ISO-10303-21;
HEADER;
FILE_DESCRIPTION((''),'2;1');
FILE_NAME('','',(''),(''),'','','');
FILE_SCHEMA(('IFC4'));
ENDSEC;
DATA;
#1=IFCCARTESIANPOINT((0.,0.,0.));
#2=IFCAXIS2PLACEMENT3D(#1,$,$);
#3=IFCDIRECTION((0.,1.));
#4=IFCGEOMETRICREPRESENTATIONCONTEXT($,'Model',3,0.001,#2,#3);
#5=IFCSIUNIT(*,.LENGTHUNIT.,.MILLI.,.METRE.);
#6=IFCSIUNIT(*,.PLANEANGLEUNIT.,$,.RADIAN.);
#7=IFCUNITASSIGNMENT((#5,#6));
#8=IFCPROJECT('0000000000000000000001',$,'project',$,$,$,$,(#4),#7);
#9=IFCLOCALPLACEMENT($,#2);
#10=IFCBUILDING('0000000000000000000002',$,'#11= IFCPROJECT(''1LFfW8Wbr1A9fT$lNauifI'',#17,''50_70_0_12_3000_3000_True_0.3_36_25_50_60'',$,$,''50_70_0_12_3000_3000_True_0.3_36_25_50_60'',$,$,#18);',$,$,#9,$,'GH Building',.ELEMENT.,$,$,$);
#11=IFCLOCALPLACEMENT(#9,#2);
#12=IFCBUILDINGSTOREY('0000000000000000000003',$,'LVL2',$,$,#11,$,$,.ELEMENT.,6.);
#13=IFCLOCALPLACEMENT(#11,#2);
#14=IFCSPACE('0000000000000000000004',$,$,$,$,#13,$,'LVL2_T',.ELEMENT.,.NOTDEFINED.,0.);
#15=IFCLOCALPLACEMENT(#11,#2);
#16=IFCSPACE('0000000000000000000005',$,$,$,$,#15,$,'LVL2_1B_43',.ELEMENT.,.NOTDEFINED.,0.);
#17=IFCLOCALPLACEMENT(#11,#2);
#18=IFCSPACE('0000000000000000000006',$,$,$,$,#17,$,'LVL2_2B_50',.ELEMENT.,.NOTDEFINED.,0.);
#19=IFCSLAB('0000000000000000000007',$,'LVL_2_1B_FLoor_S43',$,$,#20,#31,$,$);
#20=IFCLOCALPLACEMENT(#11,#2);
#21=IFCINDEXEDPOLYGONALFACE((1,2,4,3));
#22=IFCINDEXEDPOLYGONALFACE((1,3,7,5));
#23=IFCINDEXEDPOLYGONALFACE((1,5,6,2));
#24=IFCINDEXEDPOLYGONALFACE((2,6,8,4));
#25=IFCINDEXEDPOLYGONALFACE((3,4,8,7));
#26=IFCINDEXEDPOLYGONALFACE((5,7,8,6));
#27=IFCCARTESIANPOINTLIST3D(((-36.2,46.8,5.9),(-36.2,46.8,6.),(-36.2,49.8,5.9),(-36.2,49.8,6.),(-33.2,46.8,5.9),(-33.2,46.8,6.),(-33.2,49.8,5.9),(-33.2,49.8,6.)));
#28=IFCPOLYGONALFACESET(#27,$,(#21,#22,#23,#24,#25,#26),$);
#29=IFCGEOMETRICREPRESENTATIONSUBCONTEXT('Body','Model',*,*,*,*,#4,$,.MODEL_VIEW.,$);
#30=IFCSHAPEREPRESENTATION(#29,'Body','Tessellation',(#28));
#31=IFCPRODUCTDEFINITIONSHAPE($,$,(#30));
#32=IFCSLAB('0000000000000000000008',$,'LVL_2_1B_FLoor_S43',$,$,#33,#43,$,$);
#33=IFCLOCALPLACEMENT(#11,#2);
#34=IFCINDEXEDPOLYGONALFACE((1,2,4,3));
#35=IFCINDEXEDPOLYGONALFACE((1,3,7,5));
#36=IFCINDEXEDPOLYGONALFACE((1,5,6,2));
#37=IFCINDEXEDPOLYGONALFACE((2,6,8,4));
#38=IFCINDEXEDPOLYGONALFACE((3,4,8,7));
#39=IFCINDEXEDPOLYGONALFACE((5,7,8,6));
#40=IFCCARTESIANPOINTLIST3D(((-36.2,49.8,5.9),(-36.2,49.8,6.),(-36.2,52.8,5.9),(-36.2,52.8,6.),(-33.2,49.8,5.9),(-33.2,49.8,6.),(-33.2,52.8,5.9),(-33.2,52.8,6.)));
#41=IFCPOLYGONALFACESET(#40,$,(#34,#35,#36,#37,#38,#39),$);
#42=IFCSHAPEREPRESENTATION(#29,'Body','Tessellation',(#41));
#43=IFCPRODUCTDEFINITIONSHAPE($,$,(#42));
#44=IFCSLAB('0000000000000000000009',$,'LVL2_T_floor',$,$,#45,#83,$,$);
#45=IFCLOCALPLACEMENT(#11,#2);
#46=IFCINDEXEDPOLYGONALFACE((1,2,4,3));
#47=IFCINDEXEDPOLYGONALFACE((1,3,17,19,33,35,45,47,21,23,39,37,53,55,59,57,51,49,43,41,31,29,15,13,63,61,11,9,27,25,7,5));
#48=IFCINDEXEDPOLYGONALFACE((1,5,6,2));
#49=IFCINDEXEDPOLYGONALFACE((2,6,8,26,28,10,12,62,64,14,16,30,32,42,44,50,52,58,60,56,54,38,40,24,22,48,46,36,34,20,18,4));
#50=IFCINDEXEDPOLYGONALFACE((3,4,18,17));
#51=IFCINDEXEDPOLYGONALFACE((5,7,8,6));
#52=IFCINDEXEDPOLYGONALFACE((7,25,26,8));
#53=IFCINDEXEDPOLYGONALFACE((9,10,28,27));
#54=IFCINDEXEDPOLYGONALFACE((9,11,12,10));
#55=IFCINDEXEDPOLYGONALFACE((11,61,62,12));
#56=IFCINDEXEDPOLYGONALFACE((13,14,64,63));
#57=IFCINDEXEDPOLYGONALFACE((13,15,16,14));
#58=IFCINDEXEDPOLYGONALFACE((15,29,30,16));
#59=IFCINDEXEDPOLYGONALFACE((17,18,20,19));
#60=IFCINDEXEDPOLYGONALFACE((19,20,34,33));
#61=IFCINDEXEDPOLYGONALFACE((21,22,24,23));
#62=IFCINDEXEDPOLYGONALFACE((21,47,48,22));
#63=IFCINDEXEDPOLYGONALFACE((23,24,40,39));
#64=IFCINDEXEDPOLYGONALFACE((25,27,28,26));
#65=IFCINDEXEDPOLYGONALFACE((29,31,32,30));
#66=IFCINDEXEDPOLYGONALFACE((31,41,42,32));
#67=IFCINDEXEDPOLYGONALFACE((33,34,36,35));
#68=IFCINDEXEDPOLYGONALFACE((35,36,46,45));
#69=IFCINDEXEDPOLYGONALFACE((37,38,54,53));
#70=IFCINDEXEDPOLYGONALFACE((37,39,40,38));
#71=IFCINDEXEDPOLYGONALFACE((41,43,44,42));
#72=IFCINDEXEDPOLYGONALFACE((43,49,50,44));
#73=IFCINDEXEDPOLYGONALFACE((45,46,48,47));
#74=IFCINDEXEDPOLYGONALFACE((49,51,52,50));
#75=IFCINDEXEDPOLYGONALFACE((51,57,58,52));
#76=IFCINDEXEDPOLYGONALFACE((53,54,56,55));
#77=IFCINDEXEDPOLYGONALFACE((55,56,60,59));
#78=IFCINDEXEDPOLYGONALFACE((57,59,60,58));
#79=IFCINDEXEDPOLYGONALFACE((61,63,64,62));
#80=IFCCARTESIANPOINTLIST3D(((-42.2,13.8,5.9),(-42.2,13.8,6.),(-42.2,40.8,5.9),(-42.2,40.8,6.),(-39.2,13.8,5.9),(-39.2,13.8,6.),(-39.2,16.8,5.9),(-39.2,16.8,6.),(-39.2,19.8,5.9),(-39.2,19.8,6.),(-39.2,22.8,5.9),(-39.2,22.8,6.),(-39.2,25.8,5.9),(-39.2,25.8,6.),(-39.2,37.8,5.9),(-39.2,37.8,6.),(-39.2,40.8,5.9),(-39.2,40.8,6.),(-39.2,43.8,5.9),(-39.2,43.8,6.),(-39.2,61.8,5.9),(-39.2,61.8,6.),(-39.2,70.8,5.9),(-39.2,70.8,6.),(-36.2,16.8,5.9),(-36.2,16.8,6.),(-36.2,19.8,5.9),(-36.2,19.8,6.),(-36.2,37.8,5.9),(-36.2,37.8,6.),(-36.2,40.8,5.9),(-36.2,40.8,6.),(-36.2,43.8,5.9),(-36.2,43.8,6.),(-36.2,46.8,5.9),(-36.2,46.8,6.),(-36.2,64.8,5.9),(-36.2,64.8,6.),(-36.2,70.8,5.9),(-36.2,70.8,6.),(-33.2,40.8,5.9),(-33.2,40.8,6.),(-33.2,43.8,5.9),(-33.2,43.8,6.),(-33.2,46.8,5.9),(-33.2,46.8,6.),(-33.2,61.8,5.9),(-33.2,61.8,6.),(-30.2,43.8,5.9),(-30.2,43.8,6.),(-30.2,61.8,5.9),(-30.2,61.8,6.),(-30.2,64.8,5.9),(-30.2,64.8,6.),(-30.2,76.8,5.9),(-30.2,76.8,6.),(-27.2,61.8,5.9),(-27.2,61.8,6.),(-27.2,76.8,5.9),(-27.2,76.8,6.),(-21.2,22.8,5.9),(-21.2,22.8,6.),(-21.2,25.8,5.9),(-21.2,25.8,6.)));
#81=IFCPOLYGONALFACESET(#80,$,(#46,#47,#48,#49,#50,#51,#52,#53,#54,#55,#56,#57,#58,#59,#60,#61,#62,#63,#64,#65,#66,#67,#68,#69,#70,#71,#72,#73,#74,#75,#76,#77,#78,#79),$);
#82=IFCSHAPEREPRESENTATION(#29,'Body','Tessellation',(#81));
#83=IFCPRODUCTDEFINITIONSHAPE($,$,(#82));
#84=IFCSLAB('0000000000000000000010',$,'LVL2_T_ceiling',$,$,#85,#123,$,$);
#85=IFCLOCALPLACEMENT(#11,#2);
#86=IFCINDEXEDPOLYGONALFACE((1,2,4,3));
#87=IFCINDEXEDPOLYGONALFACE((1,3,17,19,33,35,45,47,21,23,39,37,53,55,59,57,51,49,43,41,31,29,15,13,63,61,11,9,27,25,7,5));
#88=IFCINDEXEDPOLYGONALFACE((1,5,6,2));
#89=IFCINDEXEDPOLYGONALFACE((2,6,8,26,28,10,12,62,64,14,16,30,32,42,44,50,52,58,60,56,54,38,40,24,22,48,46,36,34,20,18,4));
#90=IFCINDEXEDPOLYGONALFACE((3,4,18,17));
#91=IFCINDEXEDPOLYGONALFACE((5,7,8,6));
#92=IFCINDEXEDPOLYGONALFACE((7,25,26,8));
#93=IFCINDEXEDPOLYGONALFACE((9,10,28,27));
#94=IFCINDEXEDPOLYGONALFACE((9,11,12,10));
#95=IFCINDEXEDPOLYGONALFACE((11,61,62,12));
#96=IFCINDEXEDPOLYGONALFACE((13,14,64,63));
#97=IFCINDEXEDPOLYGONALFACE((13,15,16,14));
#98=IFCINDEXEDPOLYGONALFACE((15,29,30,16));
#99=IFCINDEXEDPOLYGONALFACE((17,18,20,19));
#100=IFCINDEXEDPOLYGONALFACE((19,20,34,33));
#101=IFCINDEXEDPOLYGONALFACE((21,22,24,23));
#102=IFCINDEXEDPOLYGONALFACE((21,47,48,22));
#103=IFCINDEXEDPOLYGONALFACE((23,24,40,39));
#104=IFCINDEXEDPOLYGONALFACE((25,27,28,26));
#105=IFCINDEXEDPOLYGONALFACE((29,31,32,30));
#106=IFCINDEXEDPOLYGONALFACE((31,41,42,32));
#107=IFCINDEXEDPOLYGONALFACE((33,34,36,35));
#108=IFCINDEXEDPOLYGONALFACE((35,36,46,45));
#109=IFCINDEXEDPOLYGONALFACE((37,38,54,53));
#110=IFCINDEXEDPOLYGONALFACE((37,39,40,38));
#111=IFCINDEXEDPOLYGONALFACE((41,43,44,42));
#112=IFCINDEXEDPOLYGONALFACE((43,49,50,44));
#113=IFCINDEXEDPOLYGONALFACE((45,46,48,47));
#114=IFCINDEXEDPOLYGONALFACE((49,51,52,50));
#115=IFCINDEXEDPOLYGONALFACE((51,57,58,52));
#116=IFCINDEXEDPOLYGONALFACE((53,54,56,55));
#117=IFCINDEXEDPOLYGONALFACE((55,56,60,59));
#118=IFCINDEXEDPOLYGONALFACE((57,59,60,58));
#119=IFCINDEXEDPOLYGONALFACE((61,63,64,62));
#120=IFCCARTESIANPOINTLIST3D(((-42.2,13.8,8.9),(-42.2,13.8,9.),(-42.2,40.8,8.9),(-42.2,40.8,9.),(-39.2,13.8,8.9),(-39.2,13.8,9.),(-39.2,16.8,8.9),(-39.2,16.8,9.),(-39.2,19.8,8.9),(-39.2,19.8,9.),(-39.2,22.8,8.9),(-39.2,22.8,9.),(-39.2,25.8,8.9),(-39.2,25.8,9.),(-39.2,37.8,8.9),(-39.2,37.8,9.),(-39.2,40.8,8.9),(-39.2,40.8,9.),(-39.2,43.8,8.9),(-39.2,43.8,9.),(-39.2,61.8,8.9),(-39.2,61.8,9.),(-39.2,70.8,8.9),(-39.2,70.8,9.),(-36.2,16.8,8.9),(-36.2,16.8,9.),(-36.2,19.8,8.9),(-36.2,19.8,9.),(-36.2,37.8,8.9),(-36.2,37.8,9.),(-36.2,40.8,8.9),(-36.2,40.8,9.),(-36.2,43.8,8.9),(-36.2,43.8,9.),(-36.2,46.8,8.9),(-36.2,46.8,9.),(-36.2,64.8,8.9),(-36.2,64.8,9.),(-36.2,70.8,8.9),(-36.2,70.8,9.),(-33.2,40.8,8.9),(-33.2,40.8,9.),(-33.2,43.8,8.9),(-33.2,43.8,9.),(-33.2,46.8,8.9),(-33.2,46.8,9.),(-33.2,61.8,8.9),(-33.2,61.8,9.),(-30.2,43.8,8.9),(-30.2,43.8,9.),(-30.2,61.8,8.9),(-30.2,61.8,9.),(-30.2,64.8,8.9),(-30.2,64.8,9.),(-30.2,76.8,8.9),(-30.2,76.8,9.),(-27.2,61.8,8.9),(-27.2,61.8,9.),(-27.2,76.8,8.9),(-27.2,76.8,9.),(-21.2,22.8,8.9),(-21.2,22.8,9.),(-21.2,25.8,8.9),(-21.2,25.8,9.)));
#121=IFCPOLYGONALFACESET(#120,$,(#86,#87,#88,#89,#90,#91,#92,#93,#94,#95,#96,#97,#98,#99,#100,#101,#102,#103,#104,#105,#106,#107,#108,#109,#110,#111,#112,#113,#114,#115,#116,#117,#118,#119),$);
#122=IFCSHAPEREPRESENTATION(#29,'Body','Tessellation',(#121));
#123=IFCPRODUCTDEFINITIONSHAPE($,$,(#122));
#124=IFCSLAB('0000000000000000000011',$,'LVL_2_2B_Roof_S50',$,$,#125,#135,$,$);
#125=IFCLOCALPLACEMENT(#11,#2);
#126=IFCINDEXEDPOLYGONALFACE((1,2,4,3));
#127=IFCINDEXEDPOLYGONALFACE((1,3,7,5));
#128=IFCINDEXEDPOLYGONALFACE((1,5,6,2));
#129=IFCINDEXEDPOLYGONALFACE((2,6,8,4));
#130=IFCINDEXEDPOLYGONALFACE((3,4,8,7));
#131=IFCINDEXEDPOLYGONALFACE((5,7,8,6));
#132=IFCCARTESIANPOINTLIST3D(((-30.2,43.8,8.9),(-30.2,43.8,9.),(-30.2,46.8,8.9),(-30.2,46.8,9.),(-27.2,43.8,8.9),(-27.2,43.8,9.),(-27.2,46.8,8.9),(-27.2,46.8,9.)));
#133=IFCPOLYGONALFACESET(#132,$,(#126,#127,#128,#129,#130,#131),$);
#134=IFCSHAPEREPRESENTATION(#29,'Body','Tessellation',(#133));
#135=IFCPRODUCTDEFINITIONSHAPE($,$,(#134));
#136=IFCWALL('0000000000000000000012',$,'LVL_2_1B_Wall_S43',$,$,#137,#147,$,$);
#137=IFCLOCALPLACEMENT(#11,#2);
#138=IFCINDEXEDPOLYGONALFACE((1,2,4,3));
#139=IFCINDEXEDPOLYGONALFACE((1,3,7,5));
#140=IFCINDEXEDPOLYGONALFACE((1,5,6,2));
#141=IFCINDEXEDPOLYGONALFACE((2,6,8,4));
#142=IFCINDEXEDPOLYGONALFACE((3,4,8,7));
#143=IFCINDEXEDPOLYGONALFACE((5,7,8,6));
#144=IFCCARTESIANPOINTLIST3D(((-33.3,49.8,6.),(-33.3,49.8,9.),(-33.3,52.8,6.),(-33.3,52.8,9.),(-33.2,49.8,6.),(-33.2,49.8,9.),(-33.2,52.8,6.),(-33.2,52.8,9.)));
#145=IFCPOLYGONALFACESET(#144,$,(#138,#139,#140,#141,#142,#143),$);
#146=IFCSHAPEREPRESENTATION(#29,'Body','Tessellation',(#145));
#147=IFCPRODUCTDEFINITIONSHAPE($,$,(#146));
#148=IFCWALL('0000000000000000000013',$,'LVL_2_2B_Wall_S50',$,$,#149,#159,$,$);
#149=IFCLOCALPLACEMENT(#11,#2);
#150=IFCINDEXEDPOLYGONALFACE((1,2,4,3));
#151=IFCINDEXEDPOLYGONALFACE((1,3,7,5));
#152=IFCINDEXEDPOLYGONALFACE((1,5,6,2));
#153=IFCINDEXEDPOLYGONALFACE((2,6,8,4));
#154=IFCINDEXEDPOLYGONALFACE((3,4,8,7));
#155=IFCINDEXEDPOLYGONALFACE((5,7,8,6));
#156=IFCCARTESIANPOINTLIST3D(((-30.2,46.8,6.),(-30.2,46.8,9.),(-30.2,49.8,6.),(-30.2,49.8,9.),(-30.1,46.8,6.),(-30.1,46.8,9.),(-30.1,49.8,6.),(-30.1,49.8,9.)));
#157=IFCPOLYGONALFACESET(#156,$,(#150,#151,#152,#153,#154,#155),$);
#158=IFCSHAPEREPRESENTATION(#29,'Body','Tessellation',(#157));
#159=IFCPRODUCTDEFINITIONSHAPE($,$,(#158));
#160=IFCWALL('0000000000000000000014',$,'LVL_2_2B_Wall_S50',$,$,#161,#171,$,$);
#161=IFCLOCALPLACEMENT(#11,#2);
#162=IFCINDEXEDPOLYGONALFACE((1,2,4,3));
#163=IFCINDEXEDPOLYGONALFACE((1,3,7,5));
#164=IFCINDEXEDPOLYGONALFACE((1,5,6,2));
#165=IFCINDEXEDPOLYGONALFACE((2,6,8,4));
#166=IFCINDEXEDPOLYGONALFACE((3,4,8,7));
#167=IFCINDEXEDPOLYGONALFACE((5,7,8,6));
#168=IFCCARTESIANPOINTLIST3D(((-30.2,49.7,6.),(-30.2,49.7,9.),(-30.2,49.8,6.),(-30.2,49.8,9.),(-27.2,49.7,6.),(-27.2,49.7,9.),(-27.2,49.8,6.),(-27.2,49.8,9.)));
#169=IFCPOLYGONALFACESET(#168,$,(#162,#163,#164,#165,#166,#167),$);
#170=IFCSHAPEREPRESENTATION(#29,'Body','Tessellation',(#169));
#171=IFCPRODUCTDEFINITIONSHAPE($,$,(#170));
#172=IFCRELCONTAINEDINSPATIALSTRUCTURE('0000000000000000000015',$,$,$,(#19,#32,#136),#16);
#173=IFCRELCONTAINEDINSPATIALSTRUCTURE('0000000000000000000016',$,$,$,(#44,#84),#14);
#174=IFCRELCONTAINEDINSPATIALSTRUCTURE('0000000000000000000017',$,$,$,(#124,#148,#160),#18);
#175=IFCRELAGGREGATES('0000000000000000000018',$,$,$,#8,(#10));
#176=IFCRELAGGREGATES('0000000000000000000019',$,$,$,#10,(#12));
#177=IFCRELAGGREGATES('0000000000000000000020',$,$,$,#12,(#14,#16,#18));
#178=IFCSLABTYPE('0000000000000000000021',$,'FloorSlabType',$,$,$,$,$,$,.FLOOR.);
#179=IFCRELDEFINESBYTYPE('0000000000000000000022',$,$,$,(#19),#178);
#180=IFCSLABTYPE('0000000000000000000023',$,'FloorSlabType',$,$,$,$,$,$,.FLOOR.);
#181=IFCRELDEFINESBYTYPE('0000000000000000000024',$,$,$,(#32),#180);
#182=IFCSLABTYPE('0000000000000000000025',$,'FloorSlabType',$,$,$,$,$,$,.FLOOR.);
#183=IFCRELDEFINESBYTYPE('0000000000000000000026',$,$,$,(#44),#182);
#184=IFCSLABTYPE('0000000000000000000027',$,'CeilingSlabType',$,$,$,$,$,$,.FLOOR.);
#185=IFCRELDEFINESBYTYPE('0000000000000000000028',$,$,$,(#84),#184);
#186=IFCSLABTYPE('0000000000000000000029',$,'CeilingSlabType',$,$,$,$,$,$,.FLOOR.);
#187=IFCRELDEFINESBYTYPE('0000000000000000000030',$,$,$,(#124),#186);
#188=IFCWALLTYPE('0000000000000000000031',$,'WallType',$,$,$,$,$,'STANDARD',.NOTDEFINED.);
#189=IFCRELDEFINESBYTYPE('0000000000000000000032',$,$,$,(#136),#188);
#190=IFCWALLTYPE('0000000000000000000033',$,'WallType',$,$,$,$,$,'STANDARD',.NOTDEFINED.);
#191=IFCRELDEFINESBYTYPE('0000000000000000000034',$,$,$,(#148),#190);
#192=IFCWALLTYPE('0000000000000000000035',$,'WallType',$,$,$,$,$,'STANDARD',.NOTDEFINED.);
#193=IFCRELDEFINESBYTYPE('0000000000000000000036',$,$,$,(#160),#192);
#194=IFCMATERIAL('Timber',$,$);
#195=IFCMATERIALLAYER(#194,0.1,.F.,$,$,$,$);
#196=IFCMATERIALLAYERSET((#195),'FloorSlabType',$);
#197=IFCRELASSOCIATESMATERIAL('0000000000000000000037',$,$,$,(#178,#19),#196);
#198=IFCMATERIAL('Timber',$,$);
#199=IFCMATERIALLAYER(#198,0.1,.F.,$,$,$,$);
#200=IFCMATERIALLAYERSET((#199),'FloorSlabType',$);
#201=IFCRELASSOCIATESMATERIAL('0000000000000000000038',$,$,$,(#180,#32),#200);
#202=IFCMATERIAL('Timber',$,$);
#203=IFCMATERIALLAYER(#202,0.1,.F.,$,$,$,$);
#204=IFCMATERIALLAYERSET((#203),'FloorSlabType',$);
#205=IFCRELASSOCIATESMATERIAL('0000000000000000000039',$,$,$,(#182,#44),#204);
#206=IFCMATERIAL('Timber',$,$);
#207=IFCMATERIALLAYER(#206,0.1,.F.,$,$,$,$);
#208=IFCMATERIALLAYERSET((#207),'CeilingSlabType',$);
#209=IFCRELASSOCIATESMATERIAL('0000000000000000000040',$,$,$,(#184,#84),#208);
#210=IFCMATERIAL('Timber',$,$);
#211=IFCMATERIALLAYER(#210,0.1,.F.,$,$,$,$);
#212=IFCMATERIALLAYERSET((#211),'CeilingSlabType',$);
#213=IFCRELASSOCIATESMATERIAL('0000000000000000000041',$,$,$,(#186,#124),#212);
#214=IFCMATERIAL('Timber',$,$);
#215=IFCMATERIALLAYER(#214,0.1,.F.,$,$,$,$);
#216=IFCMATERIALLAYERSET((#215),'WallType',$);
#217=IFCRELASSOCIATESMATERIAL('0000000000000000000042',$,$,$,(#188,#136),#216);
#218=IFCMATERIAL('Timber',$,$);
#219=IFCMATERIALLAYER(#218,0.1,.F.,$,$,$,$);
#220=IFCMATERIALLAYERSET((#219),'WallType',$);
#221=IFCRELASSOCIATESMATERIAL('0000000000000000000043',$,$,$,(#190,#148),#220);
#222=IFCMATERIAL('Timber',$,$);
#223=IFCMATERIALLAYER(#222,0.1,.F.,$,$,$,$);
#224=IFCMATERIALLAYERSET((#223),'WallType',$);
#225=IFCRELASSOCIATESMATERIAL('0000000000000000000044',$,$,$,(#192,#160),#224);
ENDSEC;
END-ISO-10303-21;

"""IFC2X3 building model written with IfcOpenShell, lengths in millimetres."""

from ifc_helpers import new_model, si_unit, direction, frame, frame_2d, origin, place, context, subcontext, project, spatial, polyline, rectangle, outline, extrude, material, layer, layer_set, layer_usage, type_object, element, save


model = new_model("IFC2X3")

# Units and contexts
model_context = context("Model", 3, precision=0.001, world=origin(), true_north=direction((0.0, 1.0)))
body_context = subcontext(model_context, "Body", "Model", "MODEL_VIEW")
ifc_project = project(units=[si_unit("LENGTHUNIT", "METRE", prefix="MILLI"), si_unit("PLANEANGLEUNIT", "RADIAN")], contexts=[model_context])

# Building, storey, space
building_placement = place(None, origin())
building = spatial("IfcBuilding", under=ifc_project, at=building_placement, Name="#11= IFCPROJECT('1LFfW8Wbr1A9fT$lNauifI',#17,'50_70_0_12_3000_3000_True_0.3_36_25_50_60',$,$,'50_70_0_12_3000_3000_True_0.3_36_25_50_60',$,$,#18);", LongName="GH Building", CompositionType="ELEMENT")
storey_placement = place(building_placement, origin())
storey = spatial("IfcBuildingStorey", under=building, at=storey_placement, Name="LVL2", CompositionType="ELEMENT", Elevation=6.0)
space_1_placement = place(storey_placement, origin())
space_1 = spatial("IfcSpace", under=storey, at=space_1_placement, LongName="LVL2_T", CompositionType="ELEMENT", InteriorOrExteriorSpace="NOTDEFINED", ElevationWithFlooring=0.0)

# Shared definitions
space_2_placement = place(storey_placement, origin())
space_2 = spatial("IfcSpace", under=storey, at=space_2_placement, LongName="LVL2_1B_43", CompositionType="ELEMENT", InteriorOrExteriorSpace="NOTDEFINED", ElevationWithFlooring=0.0)

# Slabs
ifc_material_1 = material(Name="Timber")
ifc_layer_1 = layer(ifc_material_1, 0.1, ventilated=False)
ifc_layer_set_1 = layer_set([ifc_layer_1], Name="FloorSlabType")
ifc_layer_usage_1 = layer_usage(ifc_layer_set_1, "AXIS3", "NEGATIVE", -0.1)
slab_type_1 = type_object("IfcSlabType", Name="FloorSlabType", PredefinedType="FLOOR", material=ifc_layer_set_1)
slab_1_placement = place(space_2_placement, frame((-33.2, 46.8, 5.9), z_axis=(0.0, 0.0, 1.0), x_axis=(0.0, 1.0, 0.0)))
element("IfcSlab", 1, at=slab_1_placement, inside=space_2, type_object=slab_type_1, material=ifc_layer_usage_1, Name="LVL_2_1B_FLoor_S43", context=body_context, shape_type="SweptSolid", body=[
    extrude(rectangle(XDim=3.0, YDim=3.0, at=frame_2d((1.5, 1.5))), origin(), (0.0, 0.0, 1.0), 0.1),
])
ifc_material_2 = material(Name="Timber")
ifc_layer_2 = layer(ifc_material_2, 0.1, ventilated=False)
ifc_layer_set_2 = layer_set([ifc_layer_2], Name="FloorSlabType")
ifc_layer_usage_2 = layer_usage(ifc_layer_set_2, "AXIS3", "NEGATIVE", -0.1)
slab_type_2 = type_object("IfcSlabType", Name="FloorSlabType", PredefinedType="FLOOR", material=ifc_layer_set_2)
slab_2_placement = place(space_2_placement, frame((-33.2, 49.8, 5.9), z_axis=(0.0, 0.0, 1.0), x_axis=(0.0, 1.0, 0.0)))
element("IfcSlab", 2, at=slab_2_placement, inside=space_2, type_object=slab_type_2, material=ifc_layer_usage_2, Name="LVL_2_1B_FLoor_S43", context=body_context, shape_type="SweptSolid", body=[
    extrude(rectangle(XDim=3.0, YDim=3.0, at=frame_2d((1.5, 1.5))), origin(), (0.0, 0.0, 1.0), 0.1),
])
ifc_material_3 = material(Name="Timber")
ifc_layer_3 = layer(ifc_material_3, 0.1, ventilated=False)
ifc_layer_set_3 = layer_set([ifc_layer_3], Name="FloorSlabType")
ifc_layer_usage_3 = layer_usage(ifc_layer_set_3, "AXIS3", "NEGATIVE", -0.1)
slab_type_3 = type_object("IfcSlabType", Name="FloorSlabType", PredefinedType="FLOOR", material=ifc_layer_set_3)
slab_3_placement = place(space_1_placement, frame((-31.7, 45.3, 5.9)))
element("IfcSlab", 3, at=slab_3_placement, inside=space_1, type_object=slab_type_3, material=ifc_layer_usage_3, Name="LVL2_T_floor", context=body_context, shape_type="SweptSolid", body=[
    extrude(outline(polyline([(-7.5, -7.5), (-4.5, -7.5), (-4.5, -4.5), (-1.5, -4.5), (-1.5, -1.5), (1.5, -1.5), (1.5, 16.5), (4.5, 16.5), (4.5, 31.5), (1.5, 31.5), (1.5, 19.5), (-4.5, 19.5), (-4.5, 25.5), (-7.5, 25.5), (-7.5, 16.5), (-1.5, 16.5), (-1.5, 1.5), (-4.5, 1.5), (-4.5, -1.5), (-7.5, -1.5), (-7.5, -4.5), (-10.5, -4.5), (-10.5, -31.5), (-7.5, -31.5), (-7.5, -28.5), (-4.5, -28.5), (-4.5, -25.5), (-7.5, -25.5), (-7.5, -22.5), (10.5, -22.5), (10.5, -19.5), (-7.5, -19.5), (-7.5, -7.5)])), origin(), (0.0, 0.0, 1.0), 0.1),
])
ifc_material_4 = material(Name="Timber")
ifc_layer_4 = layer(ifc_material_4, 0.1, ventilated=False)
ifc_layer_set_4 = layer_set([ifc_layer_4], Name="CeilingSlabType")
ifc_layer_usage_4 = layer_usage(ifc_layer_set_4, "AXIS3", "NEGATIVE", -0.1)
slab_type_4 = type_object("IfcSlabType", Name="CeilingSlabType", PredefinedType="FLOOR", material=ifc_layer_set_4)
slab_4_placement = place(space_1_placement, frame((-31.7, 45.3, 8.9)))
element("IfcSlab", 4, at=slab_4_placement, inside=space_1, type_object=slab_type_4, material=ifc_layer_usage_4, Name="LVL2_T_ceiling", context=body_context, shape_type="SweptSolid", body=[
    extrude(outline(polyline([(-7.5, -7.5), (-4.5, -7.5), (-4.5, -4.5), (-1.5, -4.5), (-1.5, -1.5), (1.5, -1.5), (1.5, 16.5), (4.5, 16.5), (4.5, 31.5), (1.5, 31.5), (1.5, 19.5), (-4.5, 19.5), (-4.5, 25.5), (-7.5, 25.5), (-7.5, 16.5), (-1.5, 16.5), (-1.5, 1.5), (-4.5, 1.5), (-4.5, -1.5), (-7.5, -1.5), (-7.5, -4.5), (-10.5, -4.5), (-10.5, -31.5), (-7.5, -31.5), (-7.5, -28.5), (-4.5, -28.5), (-4.5, -25.5), (-7.5, -25.5), (-7.5, -22.5), (10.5, -22.5), (10.5, -19.5), (-7.5, -19.5), (-7.5, -7.5)])), origin(), (0.0, 0.0, 1.0), 0.1),
])

# Shared definitions
space_3_placement = place(storey_placement, origin())
space_3 = spatial("IfcSpace", under=storey, at=space_3_placement, LongName="LVL2_2B_50", CompositionType="ELEMENT", InteriorOrExteriorSpace="NOTDEFINED", ElevationWithFlooring=0.0)

# Slab
ifc_material_5 = material(Name="Timber")
ifc_layer_5 = layer(ifc_material_5, 0.1, ventilated=False)
ifc_layer_set_5 = layer_set([ifc_layer_5], Name="CeilingSlabType")
ifc_layer_usage_5 = layer_usage(ifc_layer_set_5, "AXIS3", "NEGATIVE", -0.1)
slab_type_5 = type_object("IfcSlabType", Name="CeilingSlabType", PredefinedType="FLOOR", material=ifc_layer_set_5)
slab_5_placement = place(space_3_placement, frame((-27.2, 43.8, 8.9), z_axis=(0.0, 0.0, 1.0), x_axis=(0.0, 1.0, 0.0)))
element("IfcSlab", 5, at=slab_5_placement, inside=space_3, type_object=slab_type_5, material=ifc_layer_usage_5, Name="LVL_2_2B_Roof_S50", context=body_context, shape_type="SweptSolid", body=[
    extrude(rectangle(XDim=3.0, YDim=3.0, at=frame_2d((1.5, 1.5))), origin(), (0.0, 0.0, 1.0), 0.1),
])

# Wall
ifc_material_6 = material(Name="Timber")
ifc_layer_6 = layer(ifc_material_6, 0.1, ventilated=False)
ifc_layer_set_6 = layer_set([ifc_layer_6], Name="WallType")
ifc_layer_usage_6 = layer_usage(ifc_layer_set_6, "AXIS2", "NEGATIVE", 0.0)
wall_type_1 = type_object("IfcWallType", Name="WallType", ElementType="STANDARD", PredefinedType="NOTDEFINED", material=ifc_layer_set_6)
wall_1_placement = place(space_2_placement, frame((-33.2, 52.8, 6.0), z_axis=(0.0, 0.0, 1.0), x_axis=(0.0, -1.0, 0.0)))
element("IfcWall", 6, at=wall_1_placement, inside=space_2, type_object=wall_type_1, material=ifc_layer_usage_6, Name="LVL_2_1B_Wall_S43", context=body_context, shape_type="SweptSolid", body=[
    extrude(rectangle(XDim=3.0, YDim=0.1, at=frame_2d((1.5, -0.1))), origin(), (0.0, 0.0, 1.0), 3.0),
])

# Walls
ifc_material_7 = material(Name="Timber")
ifc_layer_7 = layer(ifc_material_7, 0.1, ventilated=False)
ifc_layer_set_7 = layer_set([ifc_layer_7], Name="WallType")
ifc_layer_usage_7 = layer_usage(ifc_layer_set_7, "AXIS2", "NEGATIVE", 0.0)
wall_type_2 = type_object("IfcWallType", Name="WallType", ElementType="STANDARD", PredefinedType="NOTDEFINED", material=ifc_layer_set_7)
wall_2_placement = place(space_3_placement, frame((-30.2, 46.8, 6.0), z_axis=(0.0, 0.0, 1.0), x_axis=(0.0, 1.0, 0.0)))
element("IfcWall", 7, at=wall_2_placement, inside=space_3, type_object=wall_type_2, material=ifc_layer_usage_7, Name="LVL_2_2B_Wall_S50", context=body_context, shape_type="SweptSolid", body=[
    extrude(rectangle(XDim=3.0, YDim=0.1, at=frame_2d((1.5, -0.1))), origin(), (0.0, 0.0, 1.0), 3.0),
])
ifc_material_8 = material(Name="Timber")
ifc_layer_8 = layer(ifc_material_8, 0.1, ventilated=False)
ifc_layer_set_8 = layer_set([ifc_layer_8], Name="WallType")
ifc_layer_usage_8 = layer_usage(ifc_layer_set_8, "AXIS2", "NEGATIVE", 0.0)
wall_type_3 = type_object("IfcWallType", Name="WallType", ElementType="STANDARD", PredefinedType="NOTDEFINED", material=ifc_layer_set_8)
wall_3_placement = place(space_3_placement, frame((-30.2, 49.8, 6.0)))
element("IfcWall", 8, at=wall_3_placement, inside=space_3, type_object=wall_type_3, material=ifc_layer_usage_8, Name="LVL_2_2B_Wall_S50", context=body_context, shape_type="SweptSolid", body=[
    extrude(rectangle(XDim=3.0, YDim=0.1, at=frame_2d((1.5, -0.1))), origin(), (0.0, 0.0, 1.0), 3.0),
])

save(model, "model.ifc")
